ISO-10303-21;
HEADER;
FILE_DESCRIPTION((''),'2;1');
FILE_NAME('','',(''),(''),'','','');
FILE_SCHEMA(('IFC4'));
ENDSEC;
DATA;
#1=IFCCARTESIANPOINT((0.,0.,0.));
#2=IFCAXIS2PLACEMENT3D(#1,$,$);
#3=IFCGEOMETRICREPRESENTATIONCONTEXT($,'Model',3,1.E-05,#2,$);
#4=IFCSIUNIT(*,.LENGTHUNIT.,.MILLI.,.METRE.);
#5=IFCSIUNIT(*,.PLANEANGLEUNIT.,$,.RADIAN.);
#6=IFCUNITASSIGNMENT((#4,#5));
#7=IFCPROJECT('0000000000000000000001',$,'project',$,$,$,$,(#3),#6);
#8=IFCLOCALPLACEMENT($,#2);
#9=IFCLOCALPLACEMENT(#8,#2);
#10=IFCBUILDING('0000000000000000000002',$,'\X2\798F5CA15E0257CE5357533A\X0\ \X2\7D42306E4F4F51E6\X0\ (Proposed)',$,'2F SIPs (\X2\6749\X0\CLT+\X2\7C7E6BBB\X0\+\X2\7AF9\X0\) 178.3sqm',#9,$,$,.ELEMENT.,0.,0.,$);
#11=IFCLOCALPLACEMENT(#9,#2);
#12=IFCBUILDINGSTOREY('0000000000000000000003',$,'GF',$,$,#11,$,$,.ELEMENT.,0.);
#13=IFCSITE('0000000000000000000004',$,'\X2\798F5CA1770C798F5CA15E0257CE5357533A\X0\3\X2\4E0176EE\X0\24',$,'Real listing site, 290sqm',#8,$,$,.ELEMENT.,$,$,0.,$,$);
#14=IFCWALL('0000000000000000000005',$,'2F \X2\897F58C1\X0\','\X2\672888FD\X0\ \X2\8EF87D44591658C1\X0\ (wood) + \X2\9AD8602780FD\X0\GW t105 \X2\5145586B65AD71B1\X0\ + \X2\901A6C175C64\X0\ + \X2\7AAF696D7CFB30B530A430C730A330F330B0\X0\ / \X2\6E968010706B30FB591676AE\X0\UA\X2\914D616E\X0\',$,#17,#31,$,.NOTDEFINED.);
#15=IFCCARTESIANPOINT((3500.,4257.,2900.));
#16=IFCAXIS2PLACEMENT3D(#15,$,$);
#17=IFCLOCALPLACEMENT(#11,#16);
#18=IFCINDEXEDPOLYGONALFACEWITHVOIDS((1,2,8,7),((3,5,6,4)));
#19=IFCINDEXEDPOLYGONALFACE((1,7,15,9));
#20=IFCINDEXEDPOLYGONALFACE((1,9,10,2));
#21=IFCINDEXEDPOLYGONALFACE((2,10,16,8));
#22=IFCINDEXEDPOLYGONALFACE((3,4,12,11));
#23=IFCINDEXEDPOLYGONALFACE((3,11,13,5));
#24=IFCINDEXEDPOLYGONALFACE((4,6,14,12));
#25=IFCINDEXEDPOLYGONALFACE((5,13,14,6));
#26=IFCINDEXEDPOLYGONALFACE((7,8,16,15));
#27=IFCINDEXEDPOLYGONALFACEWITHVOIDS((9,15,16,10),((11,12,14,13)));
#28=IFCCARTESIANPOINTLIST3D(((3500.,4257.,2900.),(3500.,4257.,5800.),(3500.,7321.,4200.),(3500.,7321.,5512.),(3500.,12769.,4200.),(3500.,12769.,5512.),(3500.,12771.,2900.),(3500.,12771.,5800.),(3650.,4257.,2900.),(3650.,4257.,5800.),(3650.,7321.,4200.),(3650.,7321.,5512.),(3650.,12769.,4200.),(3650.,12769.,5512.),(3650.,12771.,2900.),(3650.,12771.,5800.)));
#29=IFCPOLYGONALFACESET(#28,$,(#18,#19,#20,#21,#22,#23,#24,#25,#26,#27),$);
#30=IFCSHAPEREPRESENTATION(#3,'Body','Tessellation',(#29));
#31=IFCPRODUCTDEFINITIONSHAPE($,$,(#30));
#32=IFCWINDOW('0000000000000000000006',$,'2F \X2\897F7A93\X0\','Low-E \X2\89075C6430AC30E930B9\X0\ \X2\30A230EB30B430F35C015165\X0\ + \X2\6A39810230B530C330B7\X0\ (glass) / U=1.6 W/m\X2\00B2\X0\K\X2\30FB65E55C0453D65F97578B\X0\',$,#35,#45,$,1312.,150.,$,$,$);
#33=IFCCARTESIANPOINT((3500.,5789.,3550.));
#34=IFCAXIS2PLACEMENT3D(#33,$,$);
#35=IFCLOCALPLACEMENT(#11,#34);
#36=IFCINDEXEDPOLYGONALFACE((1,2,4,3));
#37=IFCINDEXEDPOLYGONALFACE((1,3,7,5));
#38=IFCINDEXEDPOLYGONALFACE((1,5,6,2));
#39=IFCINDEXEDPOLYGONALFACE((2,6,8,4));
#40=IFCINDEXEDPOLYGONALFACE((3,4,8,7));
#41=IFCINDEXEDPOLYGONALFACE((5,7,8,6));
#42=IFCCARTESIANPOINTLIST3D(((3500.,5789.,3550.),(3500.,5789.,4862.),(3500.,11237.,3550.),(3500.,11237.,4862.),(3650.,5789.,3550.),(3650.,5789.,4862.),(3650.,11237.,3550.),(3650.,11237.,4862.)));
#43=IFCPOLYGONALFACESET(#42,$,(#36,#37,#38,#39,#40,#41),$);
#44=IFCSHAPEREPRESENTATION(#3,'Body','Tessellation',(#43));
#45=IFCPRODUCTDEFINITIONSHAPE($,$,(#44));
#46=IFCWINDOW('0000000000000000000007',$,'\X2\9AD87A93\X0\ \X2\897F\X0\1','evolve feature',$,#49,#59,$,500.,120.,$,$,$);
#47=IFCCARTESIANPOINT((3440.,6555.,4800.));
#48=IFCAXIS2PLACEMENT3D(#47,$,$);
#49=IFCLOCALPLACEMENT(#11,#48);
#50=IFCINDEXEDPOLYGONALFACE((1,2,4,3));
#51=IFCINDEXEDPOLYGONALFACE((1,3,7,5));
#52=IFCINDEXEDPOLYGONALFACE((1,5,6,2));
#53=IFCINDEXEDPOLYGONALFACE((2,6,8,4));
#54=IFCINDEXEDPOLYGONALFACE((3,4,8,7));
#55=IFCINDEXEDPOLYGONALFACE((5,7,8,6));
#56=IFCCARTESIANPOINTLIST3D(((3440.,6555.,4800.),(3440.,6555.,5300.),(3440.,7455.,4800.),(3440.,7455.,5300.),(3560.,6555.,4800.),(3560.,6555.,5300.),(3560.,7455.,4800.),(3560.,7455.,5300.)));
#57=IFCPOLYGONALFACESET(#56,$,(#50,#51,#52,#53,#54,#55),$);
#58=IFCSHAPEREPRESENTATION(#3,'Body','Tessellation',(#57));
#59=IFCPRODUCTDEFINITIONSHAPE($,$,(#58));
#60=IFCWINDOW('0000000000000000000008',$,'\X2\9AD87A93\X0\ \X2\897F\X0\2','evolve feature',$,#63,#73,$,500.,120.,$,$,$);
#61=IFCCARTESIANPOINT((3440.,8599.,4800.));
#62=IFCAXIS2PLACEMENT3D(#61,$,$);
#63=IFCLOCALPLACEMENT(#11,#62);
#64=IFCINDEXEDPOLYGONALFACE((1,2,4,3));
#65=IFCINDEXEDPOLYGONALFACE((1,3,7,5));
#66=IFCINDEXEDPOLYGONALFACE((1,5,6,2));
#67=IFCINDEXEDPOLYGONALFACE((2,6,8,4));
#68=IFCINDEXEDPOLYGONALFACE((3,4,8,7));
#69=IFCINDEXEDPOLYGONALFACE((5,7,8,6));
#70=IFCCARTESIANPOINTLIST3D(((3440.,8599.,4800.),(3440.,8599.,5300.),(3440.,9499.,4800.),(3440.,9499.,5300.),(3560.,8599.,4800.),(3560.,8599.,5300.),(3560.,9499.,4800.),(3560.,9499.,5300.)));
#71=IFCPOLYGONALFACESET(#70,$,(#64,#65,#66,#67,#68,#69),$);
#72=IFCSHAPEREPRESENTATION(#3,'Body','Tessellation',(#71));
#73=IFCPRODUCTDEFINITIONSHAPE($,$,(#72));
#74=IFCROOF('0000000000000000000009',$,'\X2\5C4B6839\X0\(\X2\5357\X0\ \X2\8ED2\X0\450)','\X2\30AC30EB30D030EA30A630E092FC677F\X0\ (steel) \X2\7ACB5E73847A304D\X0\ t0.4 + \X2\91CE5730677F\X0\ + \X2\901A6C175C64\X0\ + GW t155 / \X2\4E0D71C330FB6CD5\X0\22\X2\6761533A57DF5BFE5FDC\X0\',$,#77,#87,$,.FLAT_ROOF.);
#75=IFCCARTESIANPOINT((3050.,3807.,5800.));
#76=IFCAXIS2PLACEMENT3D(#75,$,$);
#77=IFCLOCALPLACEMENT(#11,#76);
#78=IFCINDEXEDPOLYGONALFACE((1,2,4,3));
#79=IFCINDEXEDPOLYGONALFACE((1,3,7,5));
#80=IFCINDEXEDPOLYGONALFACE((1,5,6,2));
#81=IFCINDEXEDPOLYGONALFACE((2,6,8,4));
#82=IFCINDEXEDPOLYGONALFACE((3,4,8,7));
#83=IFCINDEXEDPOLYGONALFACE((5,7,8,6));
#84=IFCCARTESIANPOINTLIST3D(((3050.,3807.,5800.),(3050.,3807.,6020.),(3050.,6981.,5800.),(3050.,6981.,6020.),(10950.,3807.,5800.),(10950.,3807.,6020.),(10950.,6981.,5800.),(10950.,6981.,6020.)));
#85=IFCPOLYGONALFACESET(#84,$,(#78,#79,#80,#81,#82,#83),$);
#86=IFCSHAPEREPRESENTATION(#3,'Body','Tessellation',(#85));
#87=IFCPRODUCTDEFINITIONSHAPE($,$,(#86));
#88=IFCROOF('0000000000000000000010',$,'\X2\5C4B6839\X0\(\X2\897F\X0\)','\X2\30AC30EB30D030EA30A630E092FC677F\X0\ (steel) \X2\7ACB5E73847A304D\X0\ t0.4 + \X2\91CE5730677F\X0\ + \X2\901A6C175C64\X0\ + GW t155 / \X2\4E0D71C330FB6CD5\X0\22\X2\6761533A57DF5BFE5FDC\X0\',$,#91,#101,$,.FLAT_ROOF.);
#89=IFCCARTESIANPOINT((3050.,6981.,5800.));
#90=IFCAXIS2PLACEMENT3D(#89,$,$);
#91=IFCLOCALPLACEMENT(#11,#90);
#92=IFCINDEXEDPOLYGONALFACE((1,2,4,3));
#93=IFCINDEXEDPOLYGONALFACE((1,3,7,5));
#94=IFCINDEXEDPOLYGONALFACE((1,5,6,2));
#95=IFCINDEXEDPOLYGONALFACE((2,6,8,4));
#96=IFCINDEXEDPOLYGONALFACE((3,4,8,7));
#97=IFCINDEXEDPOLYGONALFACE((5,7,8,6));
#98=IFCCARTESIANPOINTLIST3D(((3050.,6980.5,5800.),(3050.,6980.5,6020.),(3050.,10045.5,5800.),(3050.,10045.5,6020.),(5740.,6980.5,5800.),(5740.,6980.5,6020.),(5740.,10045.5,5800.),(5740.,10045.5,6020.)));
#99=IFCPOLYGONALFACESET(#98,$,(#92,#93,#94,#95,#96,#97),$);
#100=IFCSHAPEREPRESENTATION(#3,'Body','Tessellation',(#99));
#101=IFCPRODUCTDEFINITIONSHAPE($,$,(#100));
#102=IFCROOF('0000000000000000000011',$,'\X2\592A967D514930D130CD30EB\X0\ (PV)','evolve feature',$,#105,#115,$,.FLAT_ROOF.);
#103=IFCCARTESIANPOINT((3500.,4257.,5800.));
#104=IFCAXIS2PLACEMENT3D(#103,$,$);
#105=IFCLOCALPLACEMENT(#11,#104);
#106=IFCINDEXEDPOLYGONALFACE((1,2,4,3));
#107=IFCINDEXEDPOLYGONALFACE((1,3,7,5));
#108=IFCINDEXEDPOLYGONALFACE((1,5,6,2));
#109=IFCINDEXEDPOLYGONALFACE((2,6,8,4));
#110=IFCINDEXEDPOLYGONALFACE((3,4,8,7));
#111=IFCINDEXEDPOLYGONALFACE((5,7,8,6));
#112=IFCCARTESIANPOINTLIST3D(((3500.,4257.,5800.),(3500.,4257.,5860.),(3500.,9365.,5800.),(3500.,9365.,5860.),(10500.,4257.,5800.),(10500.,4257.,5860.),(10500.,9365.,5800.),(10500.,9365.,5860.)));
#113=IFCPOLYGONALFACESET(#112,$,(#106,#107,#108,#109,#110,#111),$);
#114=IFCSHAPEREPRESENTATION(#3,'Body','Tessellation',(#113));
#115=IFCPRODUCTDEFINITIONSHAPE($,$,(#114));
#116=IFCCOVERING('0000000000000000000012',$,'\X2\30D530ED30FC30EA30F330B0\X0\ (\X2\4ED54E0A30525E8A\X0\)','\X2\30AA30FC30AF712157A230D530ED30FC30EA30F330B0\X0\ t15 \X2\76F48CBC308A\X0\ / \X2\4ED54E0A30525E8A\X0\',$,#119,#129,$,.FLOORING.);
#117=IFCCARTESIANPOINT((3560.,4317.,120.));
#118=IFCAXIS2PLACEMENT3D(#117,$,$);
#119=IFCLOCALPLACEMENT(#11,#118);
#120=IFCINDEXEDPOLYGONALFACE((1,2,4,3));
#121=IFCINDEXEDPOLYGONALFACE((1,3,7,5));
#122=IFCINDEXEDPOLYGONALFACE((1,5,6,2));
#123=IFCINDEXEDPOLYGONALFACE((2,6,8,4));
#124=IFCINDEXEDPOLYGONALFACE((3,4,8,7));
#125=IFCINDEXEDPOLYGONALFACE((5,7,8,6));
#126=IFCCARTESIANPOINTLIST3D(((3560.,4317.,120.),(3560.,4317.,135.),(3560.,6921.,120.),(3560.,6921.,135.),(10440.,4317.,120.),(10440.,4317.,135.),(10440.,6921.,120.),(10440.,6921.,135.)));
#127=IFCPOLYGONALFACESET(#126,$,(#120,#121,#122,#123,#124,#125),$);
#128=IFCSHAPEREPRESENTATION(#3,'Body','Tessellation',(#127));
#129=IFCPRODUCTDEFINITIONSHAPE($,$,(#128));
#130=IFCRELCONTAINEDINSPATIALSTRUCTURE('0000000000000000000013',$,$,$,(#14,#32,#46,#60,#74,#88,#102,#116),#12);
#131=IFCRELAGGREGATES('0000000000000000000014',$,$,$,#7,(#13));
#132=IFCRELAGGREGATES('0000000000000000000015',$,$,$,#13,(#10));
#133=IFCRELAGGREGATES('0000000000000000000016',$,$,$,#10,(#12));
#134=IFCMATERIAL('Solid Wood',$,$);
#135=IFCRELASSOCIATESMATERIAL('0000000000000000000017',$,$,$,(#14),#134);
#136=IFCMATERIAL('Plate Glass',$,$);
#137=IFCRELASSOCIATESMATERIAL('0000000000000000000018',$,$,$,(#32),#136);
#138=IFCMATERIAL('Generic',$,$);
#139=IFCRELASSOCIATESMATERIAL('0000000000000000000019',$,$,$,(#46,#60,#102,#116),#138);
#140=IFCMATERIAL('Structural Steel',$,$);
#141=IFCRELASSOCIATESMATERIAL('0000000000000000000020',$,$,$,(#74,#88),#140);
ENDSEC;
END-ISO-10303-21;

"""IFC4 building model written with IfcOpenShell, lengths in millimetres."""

from ifc_helpers import new_model, si_unit, frame, frame_2d, origin, place, context, project, spatial, rectangle, extrude, material, element, fill, save


model = new_model("IFC4")

# Units and contexts
model_context = context("Model", 3, precision=1e-05, world=origin())
ifc_project = project(units=[si_unit("LENGTHUNIT", "METRE", prefix="MILLI"), si_unit("PLANEANGLEUNIT", "RADIAN")], contexts=[model_context])

# Site, building, storey
site_placement = place(None, origin())
site = spatial("IfcSite", under=ifc_project, at=site_placement, Name="福岡県福岡市城南区3丁目24", ObjectType="Real listing site, 290sqm", CompositionType="ELEMENT", RefElevation=0.0)
building_placement = place(site_placement, origin())
building = spatial("IfcBuilding", under=site, at=building_placement, Name="福岡市城南区 終の住処 (Proposed)", ObjectType="2F SIPs (杉CLT+籾殻+竹) 178.3sqm", CompositionType="ELEMENT", ElevationOfRefHeight=0.0, ElevationOfTerrain=0.0)
storey_placement = place(building_placement, origin())
storey = spatial("IfcBuildingStorey", under=building, at=storey_placement, Name="GF", CompositionType="ELEMENT", Elevation=0.0)

# Shared definitions
ifc_material_1 = material(Name="Solid Wood")
ifc_material_2 = material(Name="Generic")

# Shared definitions
ifc_material_3 = material(Name="Plate Glass")

# Wall, openings, windows
wall_1_placement = place(storey_placement, frame((3500.0, 4257.0, 2900.0)))
wall_1 = element("IfcWall", 1, at=wall_1_placement, inside=storey, material=ifc_material_1, Name="2F 西壁", Description="木製 軸組外壁 (wood) + 高性能GW t105 充填断熱 + 通気層 + 窯業系サイディング / 準耐火・外皮UA配慮", PredefinedType="NOTDEFINED", context=model_context, shape_type="SweptSolid", body=[
    extrude(rectangle(XDim=150.0, YDim=8514.0, at=frame_2d((75.0, 4257.0))), frame((3500.0, 4257.0, 2900.0)), (0.0, 0.0, 1.0), 2900.0),
])
opening_1_placement = place(storey_placement, frame((3500.0, 5789.0, 3550.0)))
opening_1 = element("IfcOpeningElement", 2, at=opening_1_placement, cuts=wall_1, PredefinedType="NOTDEFINED", context=model_context, shape_type="SweptSolid", body=[
    extrude(rectangle(XDim=150.0, YDim=5448.0, at=frame_2d((75.0, 2724.0))), frame((3500.0, 5789.0, 3550.0)), (0.0, 0.0, 1.0), 1312.0),
])
opening_2_placement = place(storey_placement, frame((3440.0, 6555.0, 4800.0)))
opening_2 = element("IfcOpeningElement", 3, at=opening_2_placement, cuts=wall_1, PredefinedType="NOTDEFINED", context=model_context, shape_type="SweptSolid", body=[
    extrude(rectangle(XDim=120.0, YDim=900.0, at=frame_2d((60.0, 450.0))), frame((3440.0, 6555.0, 4800.0)), (0.0, 0.0, 1.0), 500.0),
])
opening_3_placement = place(storey_placement, frame((3440.0, 8599.0, 4800.0)))
opening_3 = element("IfcOpeningElement", 4, at=opening_3_placement, cuts=wall_1, PredefinedType="NOTDEFINED", context=model_context, shape_type="SweptSolid", body=[
    extrude(rectangle(XDim=120.0, YDim=900.0, at=frame_2d((60.0, 450.0))), frame((3440.0, 8599.0, 4800.0)), (0.0, 0.0, 1.0), 500.0),
])
window_1_placement = place(storey_placement, frame((3500.0, 5789.0, 3550.0)))
window_1 = element("IfcWindow", 5, at=window_1_placement, inside=storey, material=ifc_material_3, Name="2F 西窓", Description="Low-E 複層ガラス アルゴン封入 + 樹脂サッシ (glass) / U=1.6 W/m²K・日射取得型", OverallHeight=1312.0, OverallWidth=150.0, context=model_context, shape_type="SweptSolid", body=[
    extrude(rectangle(XDim=150.0, YDim=5448.0, at=frame_2d((75.0, 2724.0))), frame((3500.0, 5789.0, 3550.0)), (0.0, 0.0, 1.0), 1312.0),
])
fill(opening_1, window_1)
window_2_placement = place(storey_placement, frame((3440.0, 6555.0, 4800.0)))
window_2 = element("IfcWindow", 6, at=window_2_placement, inside=storey, material=ifc_material_2, Name="高窓 西1", Description="evolve feature", OverallHeight=500.0, OverallWidth=120.0, context=model_context, shape_type="SweptSolid", body=[
    extrude(rectangle(XDim=120.0, YDim=900.0, at=frame_2d((60.0, 450.0))), frame((3440.0, 6555.0, 4800.0)), (0.0, 0.0, 1.0), 500.0),
])
fill(opening_2, window_2)
window_3_placement = place(storey_placement, frame((3440.0, 8599.0, 4800.0)))
window_3 = element("IfcWindow", 7, at=window_3_placement, inside=storey, material=ifc_material_2, Name="高窓 西2", Description="evolve feature", OverallHeight=500.0, OverallWidth=120.0, context=model_context, shape_type="SweptSolid", body=[
    extrude(rectangle(XDim=120.0, YDim=900.0, at=frame_2d((60.0, 450.0))), frame((3440.0, 8599.0, 4800.0)), (0.0, 0.0, 1.0), 500.0),
])
fill(opening_3, window_3)

# Roofs
ifc_material_4 = material(Name="Structural Steel")
roof_1_placement = place(storey_placement, frame((3050.0, 3807.0, 5800.0)))
element("IfcRoof", 8, at=roof_1_placement, inside=storey, material=ifc_material_4, Name="屋根(南 軒450)", Description="ガルバリウム鋼板 (steel) 立平葺き t0.4 + 野地板 + 通気層 + GW t155 / 不燃・法22条区域対応", PredefinedType="FLAT_ROOF", context=model_context, shape_type="SweptSolid", body=[
    extrude(rectangle(XDim=7900.0, YDim=3174.0, at=frame_2d((3950.0, 1587.0))), frame((3050.0, 3807.0, 5800.0)), (0.0, 0.0, 1.0), 220.0),
])
roof_2_placement = place(storey_placement, frame((3050.0, 6981.0, 5800.0)))
element("IfcRoof", 9, at=roof_2_placement, inside=storey, material=ifc_material_4, Name="屋根(西)", Description="ガルバリウム鋼板 (steel) 立平葺き t0.4 + 野地板 + 通気層 + GW t155 / 不燃・法22条区域対応", PredefinedType="FLAT_ROOF", context=model_context, shape_type="SweptSolid", body=[
    extrude(rectangle(XDim=2690.0, YDim=3065.0, at=frame_2d((1345.0, 1532.0))), frame((3050.0, 6981.0, 5800.0)), (0.0, 0.0, 1.0), 220.0),
])
roof_3_placement = place(storey_placement, frame((3500.0, 4257.0, 5800.0)))
element("IfcRoof", 10, at=roof_3_placement, inside=storey, material=ifc_material_2, Name="太陽光パネル (PV)", Description="evolve feature", PredefinedType="FLAT_ROOF", context=model_context, shape_type="SweptSolid", body=[
    extrude(rectangle(XDim=7000.0, YDim=5108.0, at=frame_2d((3500.0, 2554.0))), frame((3500.0, 4257.0, 5800.0)), (0.0, 0.0, 1.0), 60.0),
])

# Covering
covering_placement = place(storey_placement, frame((3560.0, 4317.0, 120.0)))
element("IfcCovering", 11, at=covering_placement, inside=storey, material=ifc_material_2, Name="フローリング (仕上げ床)", Description="オーク無垢フローリング t15 直貼り / 仕上げ床", PredefinedType="FLOORING", context=model_context, shape_type="SweptSolid", body=[
    extrude(rectangle(XDim=6880.0, YDim=2604.0, at=frame_2d((3440.0, 1302.0))), frame((3560.0, 4317.0, 120.0)), (0.0, 0.0, 1.0), 15.0),
])

save(model, "model.ifc")
